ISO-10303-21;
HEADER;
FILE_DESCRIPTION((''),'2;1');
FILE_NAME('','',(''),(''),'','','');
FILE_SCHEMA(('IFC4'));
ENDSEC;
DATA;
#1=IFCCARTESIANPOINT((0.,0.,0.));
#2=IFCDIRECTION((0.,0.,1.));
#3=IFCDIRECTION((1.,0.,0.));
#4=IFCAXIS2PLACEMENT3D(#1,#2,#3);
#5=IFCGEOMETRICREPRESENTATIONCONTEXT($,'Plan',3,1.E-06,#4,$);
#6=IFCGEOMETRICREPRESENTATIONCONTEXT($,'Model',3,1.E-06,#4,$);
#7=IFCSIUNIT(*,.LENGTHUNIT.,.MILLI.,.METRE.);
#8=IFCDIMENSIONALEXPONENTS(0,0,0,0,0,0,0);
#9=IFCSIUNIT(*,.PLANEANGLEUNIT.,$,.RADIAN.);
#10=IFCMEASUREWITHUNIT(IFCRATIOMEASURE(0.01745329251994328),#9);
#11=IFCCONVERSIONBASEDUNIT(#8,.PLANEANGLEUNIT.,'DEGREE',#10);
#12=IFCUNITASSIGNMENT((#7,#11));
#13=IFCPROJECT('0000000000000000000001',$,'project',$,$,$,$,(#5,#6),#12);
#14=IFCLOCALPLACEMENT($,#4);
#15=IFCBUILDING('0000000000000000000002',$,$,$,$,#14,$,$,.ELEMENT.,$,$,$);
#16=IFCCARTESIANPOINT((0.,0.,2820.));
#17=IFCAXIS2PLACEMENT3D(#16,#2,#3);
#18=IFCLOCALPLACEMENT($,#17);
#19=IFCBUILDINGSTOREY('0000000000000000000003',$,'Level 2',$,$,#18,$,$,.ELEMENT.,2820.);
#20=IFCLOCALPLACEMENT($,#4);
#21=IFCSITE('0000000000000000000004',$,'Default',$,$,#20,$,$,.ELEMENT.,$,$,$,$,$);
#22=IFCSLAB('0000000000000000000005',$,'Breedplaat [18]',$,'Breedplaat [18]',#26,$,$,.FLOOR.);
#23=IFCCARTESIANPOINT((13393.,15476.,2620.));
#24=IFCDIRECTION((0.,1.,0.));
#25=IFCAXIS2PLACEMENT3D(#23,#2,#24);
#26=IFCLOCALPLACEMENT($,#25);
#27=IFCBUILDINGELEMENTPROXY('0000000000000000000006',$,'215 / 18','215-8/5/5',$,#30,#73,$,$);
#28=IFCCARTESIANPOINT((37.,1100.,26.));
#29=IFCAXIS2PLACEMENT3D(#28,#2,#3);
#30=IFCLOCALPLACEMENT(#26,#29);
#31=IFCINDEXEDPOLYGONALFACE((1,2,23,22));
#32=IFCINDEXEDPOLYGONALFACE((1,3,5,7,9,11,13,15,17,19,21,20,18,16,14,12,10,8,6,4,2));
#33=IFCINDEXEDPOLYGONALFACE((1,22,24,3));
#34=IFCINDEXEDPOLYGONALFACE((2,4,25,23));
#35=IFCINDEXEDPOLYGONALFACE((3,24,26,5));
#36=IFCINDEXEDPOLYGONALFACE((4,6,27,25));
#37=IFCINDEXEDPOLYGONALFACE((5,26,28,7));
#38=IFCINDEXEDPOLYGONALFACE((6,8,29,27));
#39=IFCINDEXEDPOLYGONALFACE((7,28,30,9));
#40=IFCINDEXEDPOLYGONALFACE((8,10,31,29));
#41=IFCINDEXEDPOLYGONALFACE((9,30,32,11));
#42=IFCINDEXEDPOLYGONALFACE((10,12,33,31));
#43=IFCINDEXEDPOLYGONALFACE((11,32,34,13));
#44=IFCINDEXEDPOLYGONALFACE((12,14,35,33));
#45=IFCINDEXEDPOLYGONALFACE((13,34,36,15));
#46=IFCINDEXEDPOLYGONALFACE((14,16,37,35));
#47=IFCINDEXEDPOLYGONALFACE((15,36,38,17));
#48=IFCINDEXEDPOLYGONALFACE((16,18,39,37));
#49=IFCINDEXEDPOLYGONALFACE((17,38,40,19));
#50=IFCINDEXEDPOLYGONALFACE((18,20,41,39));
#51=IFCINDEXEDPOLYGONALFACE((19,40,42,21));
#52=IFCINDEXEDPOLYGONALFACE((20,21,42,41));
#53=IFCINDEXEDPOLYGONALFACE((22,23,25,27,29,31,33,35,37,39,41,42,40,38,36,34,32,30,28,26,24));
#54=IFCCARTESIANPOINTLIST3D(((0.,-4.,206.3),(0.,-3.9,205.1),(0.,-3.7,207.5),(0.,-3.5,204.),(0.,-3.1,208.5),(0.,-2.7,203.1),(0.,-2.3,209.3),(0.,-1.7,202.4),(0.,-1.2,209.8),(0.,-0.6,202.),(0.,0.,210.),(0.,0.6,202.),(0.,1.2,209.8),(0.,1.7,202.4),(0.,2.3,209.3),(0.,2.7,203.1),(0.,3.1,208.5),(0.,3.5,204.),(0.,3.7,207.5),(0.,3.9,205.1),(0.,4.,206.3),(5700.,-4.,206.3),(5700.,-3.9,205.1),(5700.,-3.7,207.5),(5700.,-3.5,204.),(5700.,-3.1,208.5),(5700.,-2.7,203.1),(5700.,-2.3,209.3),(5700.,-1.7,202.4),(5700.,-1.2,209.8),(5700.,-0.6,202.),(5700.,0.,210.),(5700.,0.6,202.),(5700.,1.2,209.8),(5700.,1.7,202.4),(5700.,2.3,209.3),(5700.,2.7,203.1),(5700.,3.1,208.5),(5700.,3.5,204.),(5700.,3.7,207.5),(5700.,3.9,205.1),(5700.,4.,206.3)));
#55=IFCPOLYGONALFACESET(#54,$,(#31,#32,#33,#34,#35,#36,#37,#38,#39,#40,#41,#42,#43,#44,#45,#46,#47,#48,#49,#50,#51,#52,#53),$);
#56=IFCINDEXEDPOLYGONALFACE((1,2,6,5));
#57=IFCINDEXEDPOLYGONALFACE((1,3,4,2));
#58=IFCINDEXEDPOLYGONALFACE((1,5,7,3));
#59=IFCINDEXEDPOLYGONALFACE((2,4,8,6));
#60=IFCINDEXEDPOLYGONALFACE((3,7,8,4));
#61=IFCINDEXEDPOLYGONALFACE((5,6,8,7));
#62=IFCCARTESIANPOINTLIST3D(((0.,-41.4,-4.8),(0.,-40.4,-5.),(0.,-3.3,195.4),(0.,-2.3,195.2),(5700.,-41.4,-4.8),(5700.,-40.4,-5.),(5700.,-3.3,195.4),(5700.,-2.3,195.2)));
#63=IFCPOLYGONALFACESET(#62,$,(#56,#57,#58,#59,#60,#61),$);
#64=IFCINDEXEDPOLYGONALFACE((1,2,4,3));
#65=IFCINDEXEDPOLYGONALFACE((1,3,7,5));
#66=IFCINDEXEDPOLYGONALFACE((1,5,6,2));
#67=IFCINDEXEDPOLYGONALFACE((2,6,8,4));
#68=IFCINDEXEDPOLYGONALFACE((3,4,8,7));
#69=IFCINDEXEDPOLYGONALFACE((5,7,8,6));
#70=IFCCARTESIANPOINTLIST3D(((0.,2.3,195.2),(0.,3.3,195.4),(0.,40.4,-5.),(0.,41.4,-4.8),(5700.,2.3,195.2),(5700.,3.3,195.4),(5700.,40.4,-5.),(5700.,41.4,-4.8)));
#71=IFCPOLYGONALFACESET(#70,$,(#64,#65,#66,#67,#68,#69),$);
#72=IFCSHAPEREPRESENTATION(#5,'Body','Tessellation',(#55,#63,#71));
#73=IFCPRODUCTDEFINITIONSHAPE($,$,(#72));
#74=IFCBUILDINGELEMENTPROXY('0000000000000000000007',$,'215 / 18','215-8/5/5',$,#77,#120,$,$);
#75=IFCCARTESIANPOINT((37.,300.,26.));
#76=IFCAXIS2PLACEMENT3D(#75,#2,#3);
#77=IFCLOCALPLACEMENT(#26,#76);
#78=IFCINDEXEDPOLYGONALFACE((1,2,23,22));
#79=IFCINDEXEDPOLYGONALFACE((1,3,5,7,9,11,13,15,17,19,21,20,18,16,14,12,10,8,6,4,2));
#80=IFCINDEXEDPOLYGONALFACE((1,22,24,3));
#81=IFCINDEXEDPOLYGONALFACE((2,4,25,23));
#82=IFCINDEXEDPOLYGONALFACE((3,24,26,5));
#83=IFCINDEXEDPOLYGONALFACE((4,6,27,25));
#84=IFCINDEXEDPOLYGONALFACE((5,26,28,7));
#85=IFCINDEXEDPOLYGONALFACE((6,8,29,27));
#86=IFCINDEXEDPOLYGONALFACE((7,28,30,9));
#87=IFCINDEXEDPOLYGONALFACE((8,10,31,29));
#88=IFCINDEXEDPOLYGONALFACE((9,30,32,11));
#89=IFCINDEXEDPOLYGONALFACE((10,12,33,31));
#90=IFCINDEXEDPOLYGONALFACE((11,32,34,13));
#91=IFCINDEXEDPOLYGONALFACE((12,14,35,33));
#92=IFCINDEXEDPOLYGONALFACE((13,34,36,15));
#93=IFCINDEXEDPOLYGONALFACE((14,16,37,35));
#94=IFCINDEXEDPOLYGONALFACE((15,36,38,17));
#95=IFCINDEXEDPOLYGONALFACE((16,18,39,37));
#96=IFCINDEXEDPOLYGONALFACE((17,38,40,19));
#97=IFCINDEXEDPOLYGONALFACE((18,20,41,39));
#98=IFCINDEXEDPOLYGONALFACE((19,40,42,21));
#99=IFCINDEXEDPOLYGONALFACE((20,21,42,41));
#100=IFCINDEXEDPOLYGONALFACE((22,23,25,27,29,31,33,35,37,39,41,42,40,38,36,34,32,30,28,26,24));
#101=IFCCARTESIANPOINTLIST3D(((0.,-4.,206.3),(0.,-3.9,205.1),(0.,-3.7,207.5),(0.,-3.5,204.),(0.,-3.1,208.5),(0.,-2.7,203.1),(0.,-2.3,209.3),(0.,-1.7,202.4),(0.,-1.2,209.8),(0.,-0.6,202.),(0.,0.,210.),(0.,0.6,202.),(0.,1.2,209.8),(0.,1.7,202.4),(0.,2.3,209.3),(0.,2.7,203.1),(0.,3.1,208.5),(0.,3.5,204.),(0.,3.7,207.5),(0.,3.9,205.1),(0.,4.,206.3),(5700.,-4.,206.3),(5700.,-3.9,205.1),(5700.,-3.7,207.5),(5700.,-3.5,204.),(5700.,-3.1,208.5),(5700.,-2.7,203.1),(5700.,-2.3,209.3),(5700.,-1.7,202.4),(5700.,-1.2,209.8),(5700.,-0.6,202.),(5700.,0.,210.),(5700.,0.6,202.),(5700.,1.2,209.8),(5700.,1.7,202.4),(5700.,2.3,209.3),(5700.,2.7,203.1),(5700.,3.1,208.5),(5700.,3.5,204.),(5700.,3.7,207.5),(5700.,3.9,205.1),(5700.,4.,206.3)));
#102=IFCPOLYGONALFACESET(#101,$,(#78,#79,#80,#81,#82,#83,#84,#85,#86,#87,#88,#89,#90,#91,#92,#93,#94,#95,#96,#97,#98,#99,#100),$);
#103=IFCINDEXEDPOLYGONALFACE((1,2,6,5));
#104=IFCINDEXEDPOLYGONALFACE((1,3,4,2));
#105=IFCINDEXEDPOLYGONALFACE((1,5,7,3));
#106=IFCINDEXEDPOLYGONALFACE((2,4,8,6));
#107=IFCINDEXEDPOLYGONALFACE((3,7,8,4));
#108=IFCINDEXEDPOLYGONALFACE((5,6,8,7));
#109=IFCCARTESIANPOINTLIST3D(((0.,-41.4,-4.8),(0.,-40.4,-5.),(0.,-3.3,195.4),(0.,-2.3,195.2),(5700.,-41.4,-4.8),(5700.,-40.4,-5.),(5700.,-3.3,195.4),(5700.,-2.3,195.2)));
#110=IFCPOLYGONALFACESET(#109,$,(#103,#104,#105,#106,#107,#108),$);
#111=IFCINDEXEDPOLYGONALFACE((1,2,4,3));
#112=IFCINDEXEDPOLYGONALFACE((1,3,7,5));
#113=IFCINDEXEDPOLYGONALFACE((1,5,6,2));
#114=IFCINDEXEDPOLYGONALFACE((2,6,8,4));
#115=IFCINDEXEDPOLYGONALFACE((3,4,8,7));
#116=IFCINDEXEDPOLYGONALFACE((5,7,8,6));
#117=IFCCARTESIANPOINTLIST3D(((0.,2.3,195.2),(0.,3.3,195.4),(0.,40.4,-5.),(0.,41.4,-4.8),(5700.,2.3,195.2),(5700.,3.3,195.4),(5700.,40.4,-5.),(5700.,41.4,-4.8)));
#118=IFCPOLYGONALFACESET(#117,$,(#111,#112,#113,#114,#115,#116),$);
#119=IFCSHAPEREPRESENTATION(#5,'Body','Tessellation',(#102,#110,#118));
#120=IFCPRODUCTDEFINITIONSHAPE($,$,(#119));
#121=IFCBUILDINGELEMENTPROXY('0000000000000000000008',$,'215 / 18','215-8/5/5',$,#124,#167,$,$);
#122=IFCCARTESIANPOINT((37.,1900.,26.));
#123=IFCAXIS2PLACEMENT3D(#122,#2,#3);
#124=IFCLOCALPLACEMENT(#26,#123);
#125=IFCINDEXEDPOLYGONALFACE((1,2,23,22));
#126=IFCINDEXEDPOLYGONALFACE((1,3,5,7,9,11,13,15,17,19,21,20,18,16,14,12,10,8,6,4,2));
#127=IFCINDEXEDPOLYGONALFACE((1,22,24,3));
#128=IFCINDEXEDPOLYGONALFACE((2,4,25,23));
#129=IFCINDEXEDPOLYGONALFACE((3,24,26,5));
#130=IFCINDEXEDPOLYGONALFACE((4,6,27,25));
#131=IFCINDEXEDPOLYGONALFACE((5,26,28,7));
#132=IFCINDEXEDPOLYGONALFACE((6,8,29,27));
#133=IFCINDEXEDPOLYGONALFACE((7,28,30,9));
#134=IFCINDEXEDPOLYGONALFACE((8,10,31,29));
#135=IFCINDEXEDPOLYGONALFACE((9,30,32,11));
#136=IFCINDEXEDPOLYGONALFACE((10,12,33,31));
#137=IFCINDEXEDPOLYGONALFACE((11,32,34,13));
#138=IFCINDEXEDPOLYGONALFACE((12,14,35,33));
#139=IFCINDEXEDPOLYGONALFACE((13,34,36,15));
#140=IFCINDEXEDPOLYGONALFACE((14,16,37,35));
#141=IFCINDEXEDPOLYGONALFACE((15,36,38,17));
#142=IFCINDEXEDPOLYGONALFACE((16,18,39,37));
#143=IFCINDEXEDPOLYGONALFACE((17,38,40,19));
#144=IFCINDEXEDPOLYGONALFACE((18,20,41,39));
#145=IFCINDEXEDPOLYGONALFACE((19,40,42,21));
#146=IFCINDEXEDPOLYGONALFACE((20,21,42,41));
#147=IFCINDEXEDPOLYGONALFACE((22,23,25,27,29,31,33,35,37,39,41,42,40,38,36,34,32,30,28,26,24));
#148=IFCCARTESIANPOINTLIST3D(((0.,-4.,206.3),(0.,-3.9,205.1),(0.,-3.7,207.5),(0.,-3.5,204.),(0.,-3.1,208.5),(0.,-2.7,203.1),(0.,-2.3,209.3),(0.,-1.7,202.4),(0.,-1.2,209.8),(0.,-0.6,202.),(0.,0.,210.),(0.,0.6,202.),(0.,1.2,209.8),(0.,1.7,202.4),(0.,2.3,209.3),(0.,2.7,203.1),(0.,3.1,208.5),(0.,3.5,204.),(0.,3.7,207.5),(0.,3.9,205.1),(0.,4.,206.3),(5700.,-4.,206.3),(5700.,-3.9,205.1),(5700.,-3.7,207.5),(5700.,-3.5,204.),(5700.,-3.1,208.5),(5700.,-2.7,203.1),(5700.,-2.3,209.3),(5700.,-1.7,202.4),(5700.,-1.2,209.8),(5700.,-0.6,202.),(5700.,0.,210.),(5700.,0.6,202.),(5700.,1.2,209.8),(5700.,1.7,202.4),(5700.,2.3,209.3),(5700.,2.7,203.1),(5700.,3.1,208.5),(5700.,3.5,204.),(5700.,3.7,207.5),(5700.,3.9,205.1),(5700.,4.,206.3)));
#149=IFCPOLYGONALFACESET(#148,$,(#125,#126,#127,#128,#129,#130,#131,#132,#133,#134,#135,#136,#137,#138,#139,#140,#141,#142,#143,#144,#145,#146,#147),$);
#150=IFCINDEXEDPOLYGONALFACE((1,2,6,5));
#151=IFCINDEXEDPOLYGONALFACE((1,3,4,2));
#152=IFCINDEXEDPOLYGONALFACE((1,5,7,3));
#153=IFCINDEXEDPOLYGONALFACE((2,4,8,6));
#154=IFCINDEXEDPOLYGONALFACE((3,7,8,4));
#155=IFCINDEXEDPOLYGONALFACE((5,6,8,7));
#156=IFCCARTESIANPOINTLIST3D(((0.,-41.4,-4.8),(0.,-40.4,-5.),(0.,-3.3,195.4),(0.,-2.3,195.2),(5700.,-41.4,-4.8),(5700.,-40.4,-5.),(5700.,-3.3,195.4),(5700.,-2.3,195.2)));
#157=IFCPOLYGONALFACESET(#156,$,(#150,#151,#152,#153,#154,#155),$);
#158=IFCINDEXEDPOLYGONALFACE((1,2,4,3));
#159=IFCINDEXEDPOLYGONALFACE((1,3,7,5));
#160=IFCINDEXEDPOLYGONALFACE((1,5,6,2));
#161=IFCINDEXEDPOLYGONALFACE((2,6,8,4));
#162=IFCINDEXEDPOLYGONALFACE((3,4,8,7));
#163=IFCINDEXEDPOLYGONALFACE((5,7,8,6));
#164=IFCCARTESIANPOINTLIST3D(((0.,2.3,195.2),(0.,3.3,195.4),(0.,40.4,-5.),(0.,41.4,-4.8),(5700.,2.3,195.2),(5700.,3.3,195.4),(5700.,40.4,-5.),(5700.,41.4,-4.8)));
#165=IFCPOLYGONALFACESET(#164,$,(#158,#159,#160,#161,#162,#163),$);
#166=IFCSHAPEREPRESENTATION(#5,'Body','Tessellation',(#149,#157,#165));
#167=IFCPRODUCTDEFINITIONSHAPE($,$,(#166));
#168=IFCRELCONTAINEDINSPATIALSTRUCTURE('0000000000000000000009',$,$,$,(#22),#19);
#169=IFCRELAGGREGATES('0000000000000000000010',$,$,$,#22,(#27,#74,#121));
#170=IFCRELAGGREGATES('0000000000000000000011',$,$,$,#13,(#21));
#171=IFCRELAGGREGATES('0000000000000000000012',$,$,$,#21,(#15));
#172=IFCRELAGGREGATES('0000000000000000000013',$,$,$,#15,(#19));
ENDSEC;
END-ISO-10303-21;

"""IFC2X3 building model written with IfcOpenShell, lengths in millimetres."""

from ifc_helpers import new_model, entity, si_unit, converted_unit, frame, origin_with_axes, origin_2d_with_axis, place, context, project, spatial, rectangle, circle, extrude, element, aggregate, save


model = new_model("IFC2X3")

# Units and contexts
plan_context = context("Plan", 3, precision=1e-06, world=origin_with_axes())
model_context = context("Model", 3, precision=1e-06, world=origin_with_axes())
ifc_project = project(units=[si_unit("LENGTHUNIT", "METRE", prefix="MILLI"), converted_unit("PLANEANGLEUNIT", "DEGREE", entity("IfcRatioMeasure", 0.01745329251994328), si_unit("PLANEANGLEUNIT", "RADIAN"), dimensions=[0, 0, 0, 0, 0, 0, 0])], contexts=[plan_context, model_context])

# Site, building, storey
site_placement = place(None, origin_with_axes())
site = spatial("IfcSite", under=ifc_project, at=site_placement, Name="Default", CompositionType="ELEMENT")
building_placement = place(None, origin_with_axes())
building = spatial("IfcBuilding", under=site, at=building_placement, CompositionType="ELEMENT")
storey_placement = place(None, frame((0.0, 0.0, 2820.0), z_axis=(0.0, 0.0, 1.0), x_axis=(1.0, 0.0, 0.0)))
storey = spatial("IfcBuildingStorey", under=building, at=storey_placement, Name="Level 2", CompositionType="ELEMENT", Elevation=2820.0)

# Slab, building element proxies
slab_1_placement = place(None, frame((13393.0, 15476.0, 2620.0), z_axis=(0.0, 0.0, 1.0), x_axis=(0.0, 1.0, 0.0)))
slab_1 = element("IfcSlab", 1, at=slab_1_placement, inside=storey, Name="Breedplaat [18]", ObjectType="Breedplaat [18]", PredefinedType="FLOOR")
proxy_1_placement = place(slab_1_placement, frame((37.0, 1100.0, 26.0), z_axis=(0.0, 0.0, 1.0), x_axis=(1.0, 0.0, 0.0)))
proxy_1 = element("IfcBuildingElementProxy", 2, at=proxy_1_placement, Name="215 / 18", Description="215-8/5/5", context=plan_context, shape_type="SweptSolid", body=[
    extrude(circle(Radius=4.0, at=origin_2d_with_axis()), frame((0.0, 0.0, 206.0), z_axis=(1.0, 0.0, 0.0), x_axis=(0.0, 0.0, 1.0)), (0.0, 0.0, 1.0), 5700.0),
    extrude(rectangle(XDim=203.8, YDim=1.0, at=origin_2d_with_axis()), frame((0.0, -21.9, 95.2), z_axis=(1.0, 0.0, 0.0), x_axis=(0.0, 0.187112, 0.982339)), (0.0, 0.0, 1.0), 5700.0),
    extrude(rectangle(XDim=203.8, YDim=1.0, at=origin_2d_with_axis()), frame((0.0, 21.9, 95.2), z_axis=(1.0, 0.0, 0.0), x_axis=(0.0, -0.187112, 0.982339)), (0.0, 0.0, 1.0), 5700.0),
])
proxy_2_placement = place(slab_1_placement, frame((37.0, 300.0, 26.0), z_axis=(0.0, 0.0, 1.0), x_axis=(1.0, 0.0, 0.0)))
proxy_2 = element("IfcBuildingElementProxy", 3, at=proxy_2_placement, Name="215 / 18", Description="215-8/5/5", context=plan_context, shape_type="SweptSolid", body=[
    extrude(circle(Radius=4.0, at=origin_2d_with_axis()), frame((0.0, 0.0, 206.0), z_axis=(1.0, 0.0, 0.0), x_axis=(0.0, 0.0, 1.0)), (0.0, 0.0, 1.0), 5700.0),
    extrude(rectangle(XDim=203.8, YDim=1.0, at=origin_2d_with_axis()), frame((0.0, -21.9, 95.2), z_axis=(1.0, 0.0, 0.0), x_axis=(0.0, 0.187112, 0.982339)), (0.0, 0.0, 1.0), 5700.0),
    extrude(rectangle(XDim=203.8, YDim=1.0, at=origin_2d_with_axis()), frame((0.0, 21.9, 95.2), z_axis=(1.0, 0.0, 0.0), x_axis=(0.0, -0.187112, 0.982339)), (0.0, 0.0, 1.0), 5700.0),
])
proxy_3_placement = place(slab_1_placement, frame((37.0, 1900.0, 26.0), z_axis=(0.0, 0.0, 1.0), x_axis=(1.0, 0.0, 0.0)))
proxy_3 = element("IfcBuildingElementProxy", 4, at=proxy_3_placement, Name="215 / 18", Description="215-8/5/5", context=plan_context, shape_type="SweptSolid", body=[
    extrude(circle(Radius=4.0, at=origin_2d_with_axis()), frame((0.0, 0.0, 206.0), z_axis=(1.0, 0.0, 0.0), x_axis=(0.0, 0.0, 1.0)), (0.0, 0.0, 1.0), 5700.0),
    extrude(rectangle(XDim=203.8, YDim=1.0, at=origin_2d_with_axis()), frame((0.0, -21.9, 95.2), z_axis=(1.0, 0.0, 0.0), x_axis=(0.0, 0.187112, 0.982339)), (0.0, 0.0, 1.0), 5700.0),
    extrude(rectangle(XDim=203.8, YDim=1.0, at=origin_2d_with_axis()), frame((0.0, 21.9, 95.2), z_axis=(1.0, 0.0, 0.0), x_axis=(0.0, -0.187112, 0.982339)), (0.0, 0.0, 1.0), 5700.0),
])
aggregate(slab_1, [proxy_1, proxy_2, proxy_3])

save(model, "model.ifc")
